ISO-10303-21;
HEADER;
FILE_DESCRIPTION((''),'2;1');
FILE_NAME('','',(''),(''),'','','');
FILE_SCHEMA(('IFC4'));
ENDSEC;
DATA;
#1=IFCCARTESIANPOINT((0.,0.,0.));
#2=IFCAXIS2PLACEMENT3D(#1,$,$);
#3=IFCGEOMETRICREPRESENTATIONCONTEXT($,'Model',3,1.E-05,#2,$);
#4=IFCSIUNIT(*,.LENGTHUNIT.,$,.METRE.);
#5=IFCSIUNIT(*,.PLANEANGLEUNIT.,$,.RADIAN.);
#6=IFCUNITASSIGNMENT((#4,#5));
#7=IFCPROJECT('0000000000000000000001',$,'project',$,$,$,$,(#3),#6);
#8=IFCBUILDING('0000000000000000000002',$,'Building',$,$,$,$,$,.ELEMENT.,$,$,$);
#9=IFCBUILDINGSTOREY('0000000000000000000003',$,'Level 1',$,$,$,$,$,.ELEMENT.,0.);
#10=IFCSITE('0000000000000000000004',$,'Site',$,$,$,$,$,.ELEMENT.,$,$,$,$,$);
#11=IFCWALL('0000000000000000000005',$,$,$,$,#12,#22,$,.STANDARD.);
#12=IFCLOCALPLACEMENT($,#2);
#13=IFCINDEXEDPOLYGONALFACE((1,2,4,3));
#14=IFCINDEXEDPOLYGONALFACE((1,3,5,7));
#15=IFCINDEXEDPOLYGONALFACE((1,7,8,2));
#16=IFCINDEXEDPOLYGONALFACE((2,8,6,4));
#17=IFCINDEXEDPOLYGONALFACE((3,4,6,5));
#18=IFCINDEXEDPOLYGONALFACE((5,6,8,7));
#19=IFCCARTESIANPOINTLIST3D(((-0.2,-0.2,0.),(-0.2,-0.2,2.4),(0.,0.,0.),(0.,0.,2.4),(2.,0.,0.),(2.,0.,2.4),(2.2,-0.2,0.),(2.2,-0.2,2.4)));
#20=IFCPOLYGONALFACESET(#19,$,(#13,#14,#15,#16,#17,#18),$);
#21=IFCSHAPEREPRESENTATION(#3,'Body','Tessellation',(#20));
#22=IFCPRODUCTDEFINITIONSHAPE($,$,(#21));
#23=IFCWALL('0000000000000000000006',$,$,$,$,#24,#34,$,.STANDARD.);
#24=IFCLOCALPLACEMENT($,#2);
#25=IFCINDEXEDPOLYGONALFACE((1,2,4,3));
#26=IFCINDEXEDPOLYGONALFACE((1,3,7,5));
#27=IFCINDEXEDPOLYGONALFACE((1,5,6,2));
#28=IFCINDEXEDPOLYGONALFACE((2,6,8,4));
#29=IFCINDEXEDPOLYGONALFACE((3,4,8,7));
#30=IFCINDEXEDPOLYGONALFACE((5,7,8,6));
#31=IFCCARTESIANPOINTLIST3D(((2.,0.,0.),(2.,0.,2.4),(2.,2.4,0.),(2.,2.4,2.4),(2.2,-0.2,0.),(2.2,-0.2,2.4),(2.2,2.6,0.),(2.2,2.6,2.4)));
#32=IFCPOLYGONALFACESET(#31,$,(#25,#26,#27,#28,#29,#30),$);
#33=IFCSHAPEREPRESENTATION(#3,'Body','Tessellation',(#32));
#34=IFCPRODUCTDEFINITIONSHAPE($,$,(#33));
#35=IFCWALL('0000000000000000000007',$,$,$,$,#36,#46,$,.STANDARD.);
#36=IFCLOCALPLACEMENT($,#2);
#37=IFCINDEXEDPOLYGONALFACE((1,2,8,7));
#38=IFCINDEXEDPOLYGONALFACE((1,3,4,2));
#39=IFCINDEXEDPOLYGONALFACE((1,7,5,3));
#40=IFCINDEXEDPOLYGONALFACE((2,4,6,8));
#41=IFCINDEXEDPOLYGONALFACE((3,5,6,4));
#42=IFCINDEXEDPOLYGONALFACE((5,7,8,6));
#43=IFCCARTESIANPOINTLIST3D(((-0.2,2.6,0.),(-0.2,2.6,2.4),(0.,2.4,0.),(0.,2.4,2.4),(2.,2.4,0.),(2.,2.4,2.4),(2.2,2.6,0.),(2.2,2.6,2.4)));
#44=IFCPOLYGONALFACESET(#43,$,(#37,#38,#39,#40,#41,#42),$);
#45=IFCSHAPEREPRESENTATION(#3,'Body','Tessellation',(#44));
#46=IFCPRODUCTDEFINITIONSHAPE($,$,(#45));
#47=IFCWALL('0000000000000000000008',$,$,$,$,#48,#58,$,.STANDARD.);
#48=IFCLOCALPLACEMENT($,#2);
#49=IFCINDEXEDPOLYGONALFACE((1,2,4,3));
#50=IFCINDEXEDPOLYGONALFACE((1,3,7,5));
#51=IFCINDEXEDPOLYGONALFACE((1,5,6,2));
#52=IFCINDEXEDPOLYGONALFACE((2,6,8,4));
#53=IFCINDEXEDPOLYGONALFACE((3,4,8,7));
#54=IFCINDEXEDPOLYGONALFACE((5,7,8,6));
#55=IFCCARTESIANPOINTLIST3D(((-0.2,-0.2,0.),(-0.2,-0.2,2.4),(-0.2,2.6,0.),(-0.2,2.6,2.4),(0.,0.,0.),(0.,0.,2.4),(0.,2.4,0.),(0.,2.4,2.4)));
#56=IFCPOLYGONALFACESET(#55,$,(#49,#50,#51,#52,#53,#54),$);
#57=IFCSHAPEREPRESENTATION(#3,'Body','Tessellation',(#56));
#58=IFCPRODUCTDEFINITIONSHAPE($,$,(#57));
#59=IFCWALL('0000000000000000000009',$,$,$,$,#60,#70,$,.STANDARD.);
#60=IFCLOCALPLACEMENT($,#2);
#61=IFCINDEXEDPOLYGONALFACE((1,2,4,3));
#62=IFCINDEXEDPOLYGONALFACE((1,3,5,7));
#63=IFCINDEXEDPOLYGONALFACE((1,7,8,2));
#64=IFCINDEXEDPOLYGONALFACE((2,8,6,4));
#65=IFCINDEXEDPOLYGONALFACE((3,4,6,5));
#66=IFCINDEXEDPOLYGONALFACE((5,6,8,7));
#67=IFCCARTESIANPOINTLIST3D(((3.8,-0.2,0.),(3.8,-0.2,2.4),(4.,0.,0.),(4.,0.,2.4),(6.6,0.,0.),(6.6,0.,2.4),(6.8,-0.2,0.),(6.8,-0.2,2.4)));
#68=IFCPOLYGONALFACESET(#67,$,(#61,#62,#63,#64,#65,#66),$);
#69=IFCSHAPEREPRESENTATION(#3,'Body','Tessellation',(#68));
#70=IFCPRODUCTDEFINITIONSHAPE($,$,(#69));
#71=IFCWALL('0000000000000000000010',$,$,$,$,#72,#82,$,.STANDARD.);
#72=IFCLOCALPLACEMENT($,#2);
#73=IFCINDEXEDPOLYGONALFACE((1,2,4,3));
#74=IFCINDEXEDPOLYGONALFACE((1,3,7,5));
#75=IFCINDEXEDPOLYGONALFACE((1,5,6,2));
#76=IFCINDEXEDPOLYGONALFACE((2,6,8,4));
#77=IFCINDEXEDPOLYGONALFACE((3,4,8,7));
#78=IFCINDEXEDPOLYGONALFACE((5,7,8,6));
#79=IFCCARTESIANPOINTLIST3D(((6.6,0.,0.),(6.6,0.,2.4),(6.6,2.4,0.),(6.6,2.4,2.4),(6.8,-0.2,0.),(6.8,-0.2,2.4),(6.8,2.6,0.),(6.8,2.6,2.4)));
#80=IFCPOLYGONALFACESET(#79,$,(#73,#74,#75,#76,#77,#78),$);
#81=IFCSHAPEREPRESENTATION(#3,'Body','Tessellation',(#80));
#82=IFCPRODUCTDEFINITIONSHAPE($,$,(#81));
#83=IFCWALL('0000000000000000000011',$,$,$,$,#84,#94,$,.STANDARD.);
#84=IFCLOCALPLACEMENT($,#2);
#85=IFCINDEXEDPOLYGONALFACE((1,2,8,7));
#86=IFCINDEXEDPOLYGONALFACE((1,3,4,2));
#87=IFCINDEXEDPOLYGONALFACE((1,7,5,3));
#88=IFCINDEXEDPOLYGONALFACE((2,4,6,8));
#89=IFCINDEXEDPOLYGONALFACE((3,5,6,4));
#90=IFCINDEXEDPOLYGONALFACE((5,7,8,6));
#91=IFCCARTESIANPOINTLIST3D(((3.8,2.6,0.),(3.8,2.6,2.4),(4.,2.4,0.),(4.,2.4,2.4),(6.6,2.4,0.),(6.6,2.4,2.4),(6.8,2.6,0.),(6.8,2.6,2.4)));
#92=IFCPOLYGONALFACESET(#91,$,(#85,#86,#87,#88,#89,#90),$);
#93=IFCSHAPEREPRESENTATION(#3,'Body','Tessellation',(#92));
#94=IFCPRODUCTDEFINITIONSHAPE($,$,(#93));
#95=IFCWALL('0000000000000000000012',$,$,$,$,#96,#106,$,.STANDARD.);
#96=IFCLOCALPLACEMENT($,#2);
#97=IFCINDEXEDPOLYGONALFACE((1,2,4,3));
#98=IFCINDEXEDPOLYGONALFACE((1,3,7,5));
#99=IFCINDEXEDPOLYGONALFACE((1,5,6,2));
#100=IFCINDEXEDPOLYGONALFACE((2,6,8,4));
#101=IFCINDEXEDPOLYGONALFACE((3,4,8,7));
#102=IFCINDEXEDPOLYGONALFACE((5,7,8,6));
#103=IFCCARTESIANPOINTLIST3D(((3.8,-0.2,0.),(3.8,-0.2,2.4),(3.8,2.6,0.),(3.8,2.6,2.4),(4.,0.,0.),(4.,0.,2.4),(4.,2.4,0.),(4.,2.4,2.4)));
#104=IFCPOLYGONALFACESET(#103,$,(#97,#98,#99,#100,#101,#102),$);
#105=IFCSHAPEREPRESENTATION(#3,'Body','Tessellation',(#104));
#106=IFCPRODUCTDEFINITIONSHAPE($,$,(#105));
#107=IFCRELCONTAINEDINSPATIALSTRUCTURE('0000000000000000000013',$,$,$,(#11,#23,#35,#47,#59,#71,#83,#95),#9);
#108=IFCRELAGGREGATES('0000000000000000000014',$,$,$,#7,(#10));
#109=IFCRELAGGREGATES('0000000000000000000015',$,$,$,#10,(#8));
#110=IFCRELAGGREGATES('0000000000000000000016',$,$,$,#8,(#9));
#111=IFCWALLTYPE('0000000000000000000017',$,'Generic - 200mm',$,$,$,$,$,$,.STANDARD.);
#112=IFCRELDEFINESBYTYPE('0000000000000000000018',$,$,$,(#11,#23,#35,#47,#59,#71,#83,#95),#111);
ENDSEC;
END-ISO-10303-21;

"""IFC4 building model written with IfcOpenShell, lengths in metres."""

from ifc_helpers import new_model, si_unit, frame, origin, place, context, project, spatial, polyline, outline, extrude, type_object, element, save


model = new_model("IFC4")

# Units and contexts
model_context = context("Model", 3, precision=1e-05, world=origin())
ifc_project = project(units=[si_unit("LENGTHUNIT", "METRE"), si_unit("PLANEANGLEUNIT", "RADIAN")], contexts=[model_context])

# Site, building, storey
site = spatial("IfcSite", under=ifc_project, Name="Site", CompositionType="ELEMENT")
building = spatial("IfcBuilding", under=site, Name="Building", CompositionType="ELEMENT")
storey = spatial("IfcBuildingStorey", under=building, Name="Level 1", CompositionType="ELEMENT", Elevation=0.0)

# Walls
wall_type = type_object("IfcWallType", Name="Generic - 200mm", PredefinedType="STANDARD")
wall_1_placement = place(None, frame((-0.1, -0.1, 0.0), z_axis=(0.0, 0.0, 1.0), x_axis=(1.0, 0.0, 0.0)))
element("IfcWall", 1, at=wall_1_placement, inside=storey, type_object=wall_type, PredefinedType="STANDARD", context=model_context, shape_type="SweptSolid", body=[
    extrude(outline(polyline([(-0.1, -0.1), (2.3, -0.1), (2.1, 0.1), (0.1, 0.1), (-0.1, -0.1)])), origin(), (0.0, 0.0, 1.0), 2.4),
])
wall_2_placement = place(None, frame((2.1, -0.1, 0.0), z_axis=(0.0, 0.0, 1.0), x_axis=(0.0, 1.0, 0.0)))
element("IfcWall", 2, at=wall_2_placement, inside=storey, type_object=wall_type, PredefinedType="STANDARD", context=model_context, shape_type="SweptSolid", body=[
    extrude(outline(polyline([(-0.1, -0.1), (2.7, -0.1), (2.5, 0.1), (0.1, 0.1), (-0.1, -0.1)])), origin(), (0.0, 0.0, 1.0), 2.4),
])
wall_3_placement = place(None, frame((2.1, 2.5, 0.0), z_axis=(0.0, 0.0, 1.0), x_axis=(-1.0, 0.0, 0.0)))
element("IfcWall", 3, at=wall_3_placement, inside=storey, type_object=wall_type, PredefinedType="STANDARD", context=model_context, shape_type="SweptSolid", body=[
    extrude(outline(polyline([(-0.1, -0.1), (2.3, -0.1), (2.1, 0.1), (0.1, 0.1), (-0.1, -0.1)])), origin(), (0.0, 0.0, 1.0), 2.4),
])
wall_4_placement = place(None, frame((-0.1, 2.5, 0.0), z_axis=(0.0, 0.0, 1.0), x_axis=(0.0, -1.0, 0.0)))
element("IfcWall", 4, at=wall_4_placement, inside=storey, type_object=wall_type, PredefinedType="STANDARD", context=model_context, shape_type="SweptSolid", body=[
    extrude(outline(polyline([(-0.1, -0.1), (2.7, -0.1), (2.5, 0.1), (0.1, 0.1), (-0.1, -0.1)])), origin(), (0.0, 0.0, 1.0), 2.4),
])
wall_5_placement = place(None, frame((3.9, -0.1, 0.0), z_axis=(0.0, 0.0, 1.0), x_axis=(1.0, 0.0, 0.0)))
element("IfcWall", 5, at=wall_5_placement, inside=storey, type_object=wall_type, PredefinedType="STANDARD", context=model_context, shape_type="SweptSolid", body=[
    extrude(outline(polyline([(-0.1, -0.1), (2.9, -0.1), (2.7, 0.1), (0.1, 0.1), (-0.1, -0.1)])), origin(), (0.0, 0.0, 1.0), 2.4),
])
wall_6_placement = place(None, frame((6.7, -0.1, 0.0), z_axis=(0.0, 0.0, 1.0), x_axis=(0.0, 1.0, 0.0)))
element("IfcWall", 6, at=wall_6_placement, inside=storey, type_object=wall_type, PredefinedType="STANDARD", context=model_context, shape_type="SweptSolid", body=[
    extrude(outline(polyline([(-0.1, -0.1), (2.7, -0.1), (2.5, 0.1), (0.1, 0.1), (-0.1, -0.1)])), origin(), (0.0, 0.0, 1.0), 2.4),
])
wall_7_placement = place(None, frame((6.7, 2.5, 0.0), z_axis=(0.0, 0.0, 1.0), x_axis=(-1.0, 0.0, 0.0)))
element("IfcWall", 7, at=wall_7_placement, inside=storey, type_object=wall_type, PredefinedType="STANDARD", context=model_context, shape_type="SweptSolid", body=[
    extrude(outline(polyline([(-0.1, -0.1), (2.9, -0.1), (2.7, 0.1), (0.1, 0.1), (-0.1, -0.1)])), origin(), (0.0, 0.0, 1.0), 2.4),
])
wall_8_placement = place(None, frame((3.9, 2.5, 0.0), z_axis=(0.0, 0.0, 1.0), x_axis=(0.0, -1.0, 0.0)))
element("IfcWall", 8, at=wall_8_placement, inside=storey, type_object=wall_type, PredefinedType="STANDARD", context=model_context, shape_type="SweptSolid", body=[
    extrude(outline(polyline([(-0.1, -0.1), (2.7, -0.1), (2.5, 0.1), (0.1, 0.1), (-0.1, -0.1)])), origin(), (0.0, 0.0, 1.0), 2.4),
])

save(model, "model.ifc")
